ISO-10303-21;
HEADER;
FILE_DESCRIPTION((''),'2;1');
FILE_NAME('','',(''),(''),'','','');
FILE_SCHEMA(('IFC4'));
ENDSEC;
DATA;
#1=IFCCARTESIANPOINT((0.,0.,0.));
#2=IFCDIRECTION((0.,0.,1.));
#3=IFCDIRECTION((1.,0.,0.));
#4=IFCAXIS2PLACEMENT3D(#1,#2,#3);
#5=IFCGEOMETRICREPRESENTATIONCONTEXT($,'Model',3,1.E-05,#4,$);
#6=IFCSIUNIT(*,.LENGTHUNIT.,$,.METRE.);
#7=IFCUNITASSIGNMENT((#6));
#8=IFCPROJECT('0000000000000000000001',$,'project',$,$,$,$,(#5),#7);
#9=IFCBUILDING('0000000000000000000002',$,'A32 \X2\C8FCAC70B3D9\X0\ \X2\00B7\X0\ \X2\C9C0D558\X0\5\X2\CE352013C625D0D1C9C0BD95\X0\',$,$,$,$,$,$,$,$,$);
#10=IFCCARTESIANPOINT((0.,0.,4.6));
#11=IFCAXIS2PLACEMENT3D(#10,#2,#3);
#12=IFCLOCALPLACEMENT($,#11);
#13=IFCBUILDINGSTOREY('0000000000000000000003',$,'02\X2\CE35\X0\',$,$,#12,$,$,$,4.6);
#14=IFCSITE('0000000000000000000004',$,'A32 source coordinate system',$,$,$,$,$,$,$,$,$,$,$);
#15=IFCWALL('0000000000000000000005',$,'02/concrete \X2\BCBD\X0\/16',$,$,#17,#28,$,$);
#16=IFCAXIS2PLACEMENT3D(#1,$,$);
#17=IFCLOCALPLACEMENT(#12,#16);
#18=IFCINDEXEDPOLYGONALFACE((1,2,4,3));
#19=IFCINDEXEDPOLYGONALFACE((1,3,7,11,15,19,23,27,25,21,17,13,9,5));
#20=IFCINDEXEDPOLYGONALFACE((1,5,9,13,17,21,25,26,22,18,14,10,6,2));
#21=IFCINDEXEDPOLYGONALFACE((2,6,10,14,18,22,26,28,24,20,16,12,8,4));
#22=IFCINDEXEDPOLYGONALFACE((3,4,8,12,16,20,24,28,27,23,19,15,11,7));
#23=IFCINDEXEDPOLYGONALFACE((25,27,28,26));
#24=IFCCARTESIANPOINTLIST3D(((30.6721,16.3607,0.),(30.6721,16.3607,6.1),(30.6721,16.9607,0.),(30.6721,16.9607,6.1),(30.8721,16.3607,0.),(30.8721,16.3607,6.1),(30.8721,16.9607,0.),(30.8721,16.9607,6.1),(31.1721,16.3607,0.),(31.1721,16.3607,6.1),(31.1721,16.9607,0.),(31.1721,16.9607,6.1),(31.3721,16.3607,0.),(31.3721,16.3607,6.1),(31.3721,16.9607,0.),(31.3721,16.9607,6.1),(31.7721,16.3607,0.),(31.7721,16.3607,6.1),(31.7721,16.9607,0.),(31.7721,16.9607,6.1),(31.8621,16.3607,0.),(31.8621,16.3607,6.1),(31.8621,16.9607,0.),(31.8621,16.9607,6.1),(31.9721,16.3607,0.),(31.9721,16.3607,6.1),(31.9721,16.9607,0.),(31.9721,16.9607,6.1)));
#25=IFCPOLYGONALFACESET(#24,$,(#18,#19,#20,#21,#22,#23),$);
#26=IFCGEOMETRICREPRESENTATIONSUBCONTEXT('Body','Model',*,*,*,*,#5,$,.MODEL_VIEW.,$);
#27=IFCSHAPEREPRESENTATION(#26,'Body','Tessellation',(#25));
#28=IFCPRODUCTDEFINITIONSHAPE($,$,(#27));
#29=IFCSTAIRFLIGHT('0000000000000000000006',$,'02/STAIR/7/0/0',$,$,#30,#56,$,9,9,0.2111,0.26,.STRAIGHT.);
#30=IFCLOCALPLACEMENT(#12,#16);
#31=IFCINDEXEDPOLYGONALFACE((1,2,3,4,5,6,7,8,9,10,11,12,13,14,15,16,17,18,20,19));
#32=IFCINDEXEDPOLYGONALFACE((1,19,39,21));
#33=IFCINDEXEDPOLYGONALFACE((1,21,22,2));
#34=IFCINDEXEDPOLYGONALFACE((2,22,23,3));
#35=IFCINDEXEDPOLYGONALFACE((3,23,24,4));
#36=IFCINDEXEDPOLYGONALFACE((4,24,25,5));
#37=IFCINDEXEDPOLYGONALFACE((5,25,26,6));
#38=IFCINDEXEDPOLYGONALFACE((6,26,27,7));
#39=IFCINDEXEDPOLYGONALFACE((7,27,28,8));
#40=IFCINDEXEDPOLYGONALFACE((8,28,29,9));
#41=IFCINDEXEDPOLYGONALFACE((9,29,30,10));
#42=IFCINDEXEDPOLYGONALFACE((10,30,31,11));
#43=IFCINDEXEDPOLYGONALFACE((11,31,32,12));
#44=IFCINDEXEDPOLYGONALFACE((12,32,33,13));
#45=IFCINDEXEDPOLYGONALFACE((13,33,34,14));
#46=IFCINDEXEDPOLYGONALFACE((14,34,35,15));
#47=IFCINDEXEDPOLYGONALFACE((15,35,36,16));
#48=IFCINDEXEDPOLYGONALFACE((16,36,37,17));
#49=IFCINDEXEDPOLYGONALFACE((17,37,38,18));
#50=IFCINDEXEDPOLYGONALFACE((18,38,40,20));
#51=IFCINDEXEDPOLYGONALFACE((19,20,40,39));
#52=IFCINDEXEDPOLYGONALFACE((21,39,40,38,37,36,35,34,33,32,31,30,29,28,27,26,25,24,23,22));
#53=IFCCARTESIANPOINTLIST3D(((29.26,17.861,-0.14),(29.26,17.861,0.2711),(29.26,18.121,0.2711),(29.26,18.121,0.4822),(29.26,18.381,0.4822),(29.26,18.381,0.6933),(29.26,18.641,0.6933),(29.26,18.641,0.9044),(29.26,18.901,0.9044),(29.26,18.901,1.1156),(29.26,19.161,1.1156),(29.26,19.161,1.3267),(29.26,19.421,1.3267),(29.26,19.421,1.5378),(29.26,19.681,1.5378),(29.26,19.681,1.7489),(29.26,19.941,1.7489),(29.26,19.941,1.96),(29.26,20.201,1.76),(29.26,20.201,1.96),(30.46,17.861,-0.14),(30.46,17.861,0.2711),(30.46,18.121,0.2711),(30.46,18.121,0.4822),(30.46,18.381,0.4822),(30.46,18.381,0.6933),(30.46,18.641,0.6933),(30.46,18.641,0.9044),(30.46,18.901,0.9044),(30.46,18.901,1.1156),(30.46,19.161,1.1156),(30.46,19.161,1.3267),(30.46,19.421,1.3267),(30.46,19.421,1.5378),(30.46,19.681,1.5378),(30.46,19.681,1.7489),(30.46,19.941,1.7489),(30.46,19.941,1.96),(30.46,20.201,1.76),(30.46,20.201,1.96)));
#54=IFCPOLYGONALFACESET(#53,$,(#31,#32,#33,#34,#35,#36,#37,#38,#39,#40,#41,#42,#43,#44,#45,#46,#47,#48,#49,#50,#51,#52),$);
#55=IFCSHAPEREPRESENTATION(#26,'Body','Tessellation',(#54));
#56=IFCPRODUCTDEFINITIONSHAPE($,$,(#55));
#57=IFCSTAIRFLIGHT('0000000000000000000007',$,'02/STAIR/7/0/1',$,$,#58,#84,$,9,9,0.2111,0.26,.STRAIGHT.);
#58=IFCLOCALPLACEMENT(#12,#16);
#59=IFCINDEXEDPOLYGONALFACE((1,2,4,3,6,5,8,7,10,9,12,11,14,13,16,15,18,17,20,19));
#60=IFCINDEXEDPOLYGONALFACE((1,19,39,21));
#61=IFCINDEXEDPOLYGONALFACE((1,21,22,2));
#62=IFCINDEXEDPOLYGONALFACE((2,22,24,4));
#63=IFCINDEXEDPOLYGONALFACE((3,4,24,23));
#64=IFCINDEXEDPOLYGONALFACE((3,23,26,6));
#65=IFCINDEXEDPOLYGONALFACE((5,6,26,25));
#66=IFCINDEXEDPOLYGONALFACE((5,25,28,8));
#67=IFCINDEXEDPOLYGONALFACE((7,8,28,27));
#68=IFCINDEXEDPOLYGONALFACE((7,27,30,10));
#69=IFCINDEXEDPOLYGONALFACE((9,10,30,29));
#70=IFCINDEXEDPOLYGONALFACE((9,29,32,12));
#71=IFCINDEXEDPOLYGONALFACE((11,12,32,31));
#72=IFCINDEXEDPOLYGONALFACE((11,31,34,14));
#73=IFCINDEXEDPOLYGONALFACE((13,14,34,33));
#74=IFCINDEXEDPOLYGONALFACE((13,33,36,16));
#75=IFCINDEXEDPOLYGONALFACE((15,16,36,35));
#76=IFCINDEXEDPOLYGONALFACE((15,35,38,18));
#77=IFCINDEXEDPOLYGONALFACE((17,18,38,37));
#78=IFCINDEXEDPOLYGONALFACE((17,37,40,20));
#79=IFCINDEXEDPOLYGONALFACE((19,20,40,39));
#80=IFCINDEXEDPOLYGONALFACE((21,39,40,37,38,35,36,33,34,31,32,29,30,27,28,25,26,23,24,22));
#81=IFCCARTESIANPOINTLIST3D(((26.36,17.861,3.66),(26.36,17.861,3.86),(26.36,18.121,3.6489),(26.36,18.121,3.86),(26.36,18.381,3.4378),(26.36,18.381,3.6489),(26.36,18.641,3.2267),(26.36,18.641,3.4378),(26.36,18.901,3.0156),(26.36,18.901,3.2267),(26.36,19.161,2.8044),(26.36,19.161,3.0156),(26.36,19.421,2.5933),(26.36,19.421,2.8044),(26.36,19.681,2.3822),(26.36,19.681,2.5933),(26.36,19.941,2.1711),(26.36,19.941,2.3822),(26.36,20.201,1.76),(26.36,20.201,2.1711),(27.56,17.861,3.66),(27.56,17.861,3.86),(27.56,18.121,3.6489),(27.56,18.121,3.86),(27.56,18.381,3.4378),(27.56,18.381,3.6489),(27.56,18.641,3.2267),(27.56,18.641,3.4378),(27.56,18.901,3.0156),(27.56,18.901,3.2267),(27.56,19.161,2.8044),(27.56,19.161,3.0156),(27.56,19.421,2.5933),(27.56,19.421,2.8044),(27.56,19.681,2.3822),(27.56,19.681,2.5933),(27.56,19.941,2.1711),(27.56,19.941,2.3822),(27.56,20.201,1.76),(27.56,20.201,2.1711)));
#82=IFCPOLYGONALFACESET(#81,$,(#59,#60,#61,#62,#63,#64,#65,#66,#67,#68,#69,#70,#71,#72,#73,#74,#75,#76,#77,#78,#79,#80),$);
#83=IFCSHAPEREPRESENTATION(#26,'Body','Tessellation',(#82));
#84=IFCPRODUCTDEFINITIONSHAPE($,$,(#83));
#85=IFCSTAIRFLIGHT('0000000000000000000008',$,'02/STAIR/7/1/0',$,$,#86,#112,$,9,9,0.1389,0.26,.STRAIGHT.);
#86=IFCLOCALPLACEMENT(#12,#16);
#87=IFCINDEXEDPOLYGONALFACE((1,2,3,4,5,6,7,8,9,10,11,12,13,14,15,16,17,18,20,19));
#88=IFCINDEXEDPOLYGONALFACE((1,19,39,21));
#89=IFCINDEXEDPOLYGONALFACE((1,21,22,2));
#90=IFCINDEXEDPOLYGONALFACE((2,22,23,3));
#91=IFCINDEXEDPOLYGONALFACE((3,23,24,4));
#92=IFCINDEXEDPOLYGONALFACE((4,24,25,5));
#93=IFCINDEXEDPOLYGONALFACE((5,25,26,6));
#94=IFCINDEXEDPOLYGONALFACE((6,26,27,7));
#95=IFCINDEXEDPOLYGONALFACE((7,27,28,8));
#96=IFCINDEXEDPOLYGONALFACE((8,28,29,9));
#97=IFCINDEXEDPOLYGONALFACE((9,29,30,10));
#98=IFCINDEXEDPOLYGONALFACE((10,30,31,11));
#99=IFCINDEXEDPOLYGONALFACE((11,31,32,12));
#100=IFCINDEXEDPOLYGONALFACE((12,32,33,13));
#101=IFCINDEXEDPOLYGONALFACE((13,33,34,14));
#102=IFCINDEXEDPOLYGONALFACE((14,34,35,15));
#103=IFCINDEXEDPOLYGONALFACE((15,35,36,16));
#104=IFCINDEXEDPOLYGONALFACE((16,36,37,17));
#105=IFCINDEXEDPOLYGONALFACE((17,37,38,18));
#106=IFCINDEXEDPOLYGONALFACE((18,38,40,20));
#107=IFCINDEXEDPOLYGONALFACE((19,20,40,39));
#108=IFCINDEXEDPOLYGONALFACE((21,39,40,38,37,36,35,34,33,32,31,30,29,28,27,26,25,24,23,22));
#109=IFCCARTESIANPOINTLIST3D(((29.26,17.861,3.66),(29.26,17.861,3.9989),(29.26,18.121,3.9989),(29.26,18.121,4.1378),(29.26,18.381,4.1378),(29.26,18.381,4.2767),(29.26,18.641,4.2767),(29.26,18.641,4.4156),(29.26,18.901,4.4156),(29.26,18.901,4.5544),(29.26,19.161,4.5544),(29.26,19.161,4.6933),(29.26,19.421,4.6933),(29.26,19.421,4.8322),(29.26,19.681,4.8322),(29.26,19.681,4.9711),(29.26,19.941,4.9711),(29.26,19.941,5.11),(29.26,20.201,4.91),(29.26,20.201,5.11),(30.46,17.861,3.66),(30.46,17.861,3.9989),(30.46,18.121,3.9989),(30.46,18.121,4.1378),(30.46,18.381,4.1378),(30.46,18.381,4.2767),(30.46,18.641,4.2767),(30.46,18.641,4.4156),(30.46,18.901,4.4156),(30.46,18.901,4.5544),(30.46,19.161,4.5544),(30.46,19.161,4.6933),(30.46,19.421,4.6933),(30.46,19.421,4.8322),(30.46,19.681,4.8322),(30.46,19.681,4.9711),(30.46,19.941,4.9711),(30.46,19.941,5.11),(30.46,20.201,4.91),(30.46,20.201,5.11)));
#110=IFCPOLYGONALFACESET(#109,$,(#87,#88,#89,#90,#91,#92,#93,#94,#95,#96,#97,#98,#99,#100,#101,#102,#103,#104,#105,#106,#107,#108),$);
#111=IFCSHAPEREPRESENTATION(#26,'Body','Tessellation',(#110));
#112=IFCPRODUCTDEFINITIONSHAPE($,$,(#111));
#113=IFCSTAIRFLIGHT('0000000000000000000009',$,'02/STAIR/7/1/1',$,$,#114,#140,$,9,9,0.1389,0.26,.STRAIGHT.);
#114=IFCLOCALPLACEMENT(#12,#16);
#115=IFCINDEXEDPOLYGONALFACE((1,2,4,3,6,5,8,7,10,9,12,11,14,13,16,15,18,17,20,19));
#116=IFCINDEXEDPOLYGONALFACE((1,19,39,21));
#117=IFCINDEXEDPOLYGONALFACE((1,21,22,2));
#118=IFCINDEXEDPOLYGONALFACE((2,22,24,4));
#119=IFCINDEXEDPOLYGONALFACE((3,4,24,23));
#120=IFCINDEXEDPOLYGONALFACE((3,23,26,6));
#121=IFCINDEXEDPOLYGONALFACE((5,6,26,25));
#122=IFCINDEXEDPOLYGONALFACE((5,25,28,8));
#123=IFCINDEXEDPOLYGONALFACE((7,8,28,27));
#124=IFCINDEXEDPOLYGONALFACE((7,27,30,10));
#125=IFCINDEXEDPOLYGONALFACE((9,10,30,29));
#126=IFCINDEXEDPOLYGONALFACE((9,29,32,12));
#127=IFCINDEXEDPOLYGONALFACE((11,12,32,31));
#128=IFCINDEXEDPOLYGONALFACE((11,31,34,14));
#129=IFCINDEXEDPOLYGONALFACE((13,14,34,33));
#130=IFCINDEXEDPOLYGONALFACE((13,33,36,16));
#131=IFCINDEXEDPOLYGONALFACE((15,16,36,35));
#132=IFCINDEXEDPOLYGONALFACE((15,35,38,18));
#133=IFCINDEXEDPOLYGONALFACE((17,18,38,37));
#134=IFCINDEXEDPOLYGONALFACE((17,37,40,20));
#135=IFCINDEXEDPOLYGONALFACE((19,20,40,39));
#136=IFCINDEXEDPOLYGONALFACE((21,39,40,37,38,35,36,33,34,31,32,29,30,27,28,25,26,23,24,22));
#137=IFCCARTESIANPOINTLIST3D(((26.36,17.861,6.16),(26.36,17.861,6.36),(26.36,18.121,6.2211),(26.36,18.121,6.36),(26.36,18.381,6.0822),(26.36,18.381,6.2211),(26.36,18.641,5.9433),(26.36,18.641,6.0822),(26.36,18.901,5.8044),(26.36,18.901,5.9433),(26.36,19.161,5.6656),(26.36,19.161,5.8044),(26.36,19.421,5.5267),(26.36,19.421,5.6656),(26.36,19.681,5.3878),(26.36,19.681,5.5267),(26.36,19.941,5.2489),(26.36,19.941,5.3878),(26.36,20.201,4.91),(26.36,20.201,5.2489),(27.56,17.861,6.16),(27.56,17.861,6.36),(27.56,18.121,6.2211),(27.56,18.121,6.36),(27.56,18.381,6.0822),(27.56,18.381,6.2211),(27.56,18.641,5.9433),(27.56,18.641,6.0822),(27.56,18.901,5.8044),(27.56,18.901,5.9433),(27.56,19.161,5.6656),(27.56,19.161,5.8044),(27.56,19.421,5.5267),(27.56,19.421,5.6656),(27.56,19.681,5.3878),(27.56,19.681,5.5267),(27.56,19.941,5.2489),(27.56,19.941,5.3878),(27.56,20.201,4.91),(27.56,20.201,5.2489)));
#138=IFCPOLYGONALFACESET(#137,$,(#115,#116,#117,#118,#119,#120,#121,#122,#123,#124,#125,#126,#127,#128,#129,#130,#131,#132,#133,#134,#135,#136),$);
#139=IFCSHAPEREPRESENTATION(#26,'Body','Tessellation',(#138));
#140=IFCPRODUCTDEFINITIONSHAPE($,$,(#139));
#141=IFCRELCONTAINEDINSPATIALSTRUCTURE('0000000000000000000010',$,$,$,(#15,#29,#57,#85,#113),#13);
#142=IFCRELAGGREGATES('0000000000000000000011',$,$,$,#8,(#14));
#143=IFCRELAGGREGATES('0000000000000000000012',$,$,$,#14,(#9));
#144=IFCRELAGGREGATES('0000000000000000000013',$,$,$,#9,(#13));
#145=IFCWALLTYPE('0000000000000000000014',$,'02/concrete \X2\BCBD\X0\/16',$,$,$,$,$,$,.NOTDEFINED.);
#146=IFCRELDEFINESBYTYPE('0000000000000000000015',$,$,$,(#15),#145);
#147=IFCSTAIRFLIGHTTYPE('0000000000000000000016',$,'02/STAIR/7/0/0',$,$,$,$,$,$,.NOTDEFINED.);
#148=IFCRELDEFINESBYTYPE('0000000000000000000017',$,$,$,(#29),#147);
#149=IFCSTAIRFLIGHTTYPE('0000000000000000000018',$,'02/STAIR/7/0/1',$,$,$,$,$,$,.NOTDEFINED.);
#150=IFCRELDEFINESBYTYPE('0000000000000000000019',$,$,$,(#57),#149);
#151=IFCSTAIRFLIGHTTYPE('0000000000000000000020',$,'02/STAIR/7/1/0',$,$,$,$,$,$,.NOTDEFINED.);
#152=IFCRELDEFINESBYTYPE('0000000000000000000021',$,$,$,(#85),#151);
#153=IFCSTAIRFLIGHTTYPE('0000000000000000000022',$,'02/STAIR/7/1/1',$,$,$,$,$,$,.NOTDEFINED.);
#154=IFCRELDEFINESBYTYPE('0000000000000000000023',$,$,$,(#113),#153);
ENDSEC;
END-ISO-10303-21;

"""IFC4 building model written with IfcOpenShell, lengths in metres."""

from ifc_helpers import new_model, si_unit, frame, origin, origin_with_axes, place, context, subcontext, project, spatial, polyline, outline, extrude, source, transform, mapped, type_object, type_shapes, element, save


model = new_model("IFC4")

# Units and contexts
model_context = context("Model", 3, precision=1e-05, world=origin_with_axes())
body_context = subcontext(model_context, "Body", "Model", "MODEL_VIEW")
ifc_project = project(units=[si_unit("LENGTHUNIT", "METRE")], contexts=[model_context])

# Site, building, storey
site = spatial("IfcSite", under=ifc_project, Name="A32 source coordinate system")
building = spatial("IfcBuilding", under=site, Name="A32 주거동 · 지하5층–옥탑지붕")
storey_placement = place(None, frame((0.0, 0.0, 4.6), z_axis=(0.0, 0.0, 1.0), x_axis=(1.0, 0.0, 0.0)))
storey = spatial("IfcBuildingStorey", under=building, at=storey_placement, Name="02층", Elevation=4.6)

# Wall
wall_type_1 = type_object("IfcWallType", Name="02/concrete 벽/16", PredefinedType="NOTDEFINED")
shared_shape_1 = source(origin(), body_context, "Body", "SweptSolid", [
    extrude(outline(polyline([(31.3721, 16.9607), (31.7721, 16.9607), (31.8621, 16.9607), (31.9721, 16.9607), (31.9721, 16.3607), (31.8621, 16.3607), (31.7721, 16.3607), (31.3721, 16.3607), (31.1721, 16.3607), (30.8721, 16.3607), (30.6721, 16.3607), (30.6721, 16.9607), (30.8721, 16.9607), (31.1721, 16.9607), (31.3721, 16.9607)])), origin(), (0.0, 0.0, 1.0), 6.1),
])
type_shapes(wall_type_1, [shared_shape_1])
wall_1_placement = place(storey_placement, origin_with_axes())
element("IfcWall", 1, at=wall_1_placement, inside=storey, type_object=wall_type_1, Name="02/concrete 벽/16", context=body_context, shape_type="MappedRepresentation", body=[
    mapped(shared_shape_1, transform((0.0, 0.0, 0.0), scale=1.0)),
])

# Stair flights
stair_flight_type_1 = type_object("IfcStairFlightType", Name="02/STAIR/7/0/0", PredefinedType="NOTDEFINED")
shared_shape_2 = source(origin(), body_context, "Body", "SweptSolid", [
    extrude(outline(polyline([(0.0, -0.14), (2.34, 1.76), (2.34, 1.96), (2.08, 1.96), (2.08, 1.7489), (1.82, 1.7489), (1.82, 1.5378), (1.56, 1.5378), (1.56, 1.3267), (1.3, 1.3267), (1.3, 1.1156), (1.04, 1.1156), (1.04, 0.9044), (0.78, 0.9044), (0.78, 0.6933), (0.52, 0.6933), (0.52, 0.4822), (0.26, 0.4822), (0.26, 0.2711), (0.0, 0.2711), (0.0, -0.14)])), frame((29.26, 17.861, 0.0), z_axis=(1.0, 0.0, 0.0), x_axis=(0.0, 1.0, 0.0)), (0.0, 0.0, 1.0), 1.2),
])
type_shapes(stair_flight_type_1, [shared_shape_2])
stair_flight_1_placement = place(storey_placement, origin_with_axes())
element("IfcStairFlight", 2, at=stair_flight_1_placement, inside=storey, type_object=stair_flight_type_1, Name="02/STAIR/7/0/0", NumberOfRisers=9, NumberOfTreads=9, PredefinedType="STRAIGHT", RiserHeight=0.2111, TreadLength=0.26, context=body_context, shape_type="MappedRepresentation", body=[
    mapped(shared_shape_2, transform((0.0, 0.0, 0.0), scale=1.0)),
])
stair_flight_type_2 = type_object("IfcStairFlightType", Name="02/STAIR/7/0/1", PredefinedType="NOTDEFINED")
shared_shape_3 = source(origin(), body_context, "Body", "SweptSolid", [
    extrude(outline(polyline([(0.0, 1.76), (2.34, 3.66), (2.34, 3.86), (2.08, 3.86), (2.08, 3.6489), (1.82, 3.6489), (1.82, 3.4378), (1.56, 3.4378), (1.56, 3.2267), (1.3, 3.2267), (1.3, 3.0156), (1.04, 3.0156), (1.04, 2.8044), (0.78, 2.8044), (0.78, 2.5933), (0.52, 2.5933), (0.52, 2.3822), (0.26, 2.3822), (0.26, 2.1711), (0.0, 2.1711), (0.0, 1.76)])), frame((27.56, 20.201, 0.0), z_axis=(-1.0, 0.0, 0.0), x_axis=(0.0, -1.0, 0.0)), (0.0, 0.0, 1.0), 1.2),
])
type_shapes(stair_flight_type_2, [shared_shape_3])
stair_flight_2_placement = place(storey_placement, origin_with_axes())
element("IfcStairFlight", 3, at=stair_flight_2_placement, inside=storey, type_object=stair_flight_type_2, Name="02/STAIR/7/0/1", NumberOfRisers=9, NumberOfTreads=9, PredefinedType="STRAIGHT", RiserHeight=0.2111, TreadLength=0.26, context=body_context, shape_type="MappedRepresentation", body=[
    mapped(shared_shape_3, transform((0.0, 0.0, 0.0), scale=1.0)),
])
stair_flight_type_3 = type_object("IfcStairFlightType", Name="02/STAIR/7/1/0", PredefinedType="NOTDEFINED")
shared_shape_4 = source(origin(), body_context, "Body", "SweptSolid", [
    extrude(outline(polyline([(0.0, 3.66), (2.34, 4.91), (2.34, 5.11), (2.08, 5.11), (2.08, 4.9711), (1.82, 4.9711), (1.82, 4.8322), (1.56, 4.8322), (1.56, 4.6933), (1.3, 4.6933), (1.3, 4.5544), (1.04, 4.5544), (1.04, 4.4156), (0.78, 4.4156), (0.78, 4.2767), (0.52, 4.2767), (0.52, 4.1378), (0.26, 4.1378), (0.26, 3.9989), (0.0, 3.9989), (0.0, 3.66)])), frame((29.26, 17.861, 0.0), z_axis=(1.0, 0.0, 0.0), x_axis=(0.0, 1.0, 0.0)), (0.0, 0.0, 1.0), 1.2),
])
type_shapes(stair_flight_type_3, [shared_shape_4])
stair_flight_3_placement = place(storey_placement, origin_with_axes())
element("IfcStairFlight", 4, at=stair_flight_3_placement, inside=storey, type_object=stair_flight_type_3, Name="02/STAIR/7/1/0", NumberOfRisers=9, NumberOfTreads=9, PredefinedType="STRAIGHT", RiserHeight=0.1389, TreadLength=0.26, context=body_context, shape_type="MappedRepresentation", body=[
    mapped(shared_shape_4, transform((0.0, 0.0, 0.0), scale=1.0)),
])
stair_flight_type_4 = type_object("IfcStairFlightType", Name="02/STAIR/7/1/1", PredefinedType="NOTDEFINED")
shared_shape_5 = source(origin(), body_context, "Body", "SweptSolid", [
    extrude(outline(polyline([(0.0, 4.91), (2.34, 6.16), (2.34, 6.36), (2.08, 6.36), (2.08, 6.2211), (1.82, 6.2211), (1.82, 6.0822), (1.56, 6.0822), (1.56, 5.9433), (1.3, 5.9433), (1.3, 5.8044), (1.04, 5.8044), (1.04, 5.6656), (0.78, 5.6656), (0.78, 5.5267), (0.52, 5.5267), (0.52, 5.3878), (0.26, 5.3878), (0.26, 5.2489), (0.0, 5.2489), (0.0, 4.91)])), frame((27.56, 20.201, 0.0), z_axis=(-1.0, 0.0, 0.0), x_axis=(0.0, -1.0, 0.0)), (0.0, 0.0, 1.0), 1.2),
])
type_shapes(stair_flight_type_4, [shared_shape_5])
stair_flight_4_placement = place(storey_placement, origin_with_axes())
element("IfcStairFlight", 5, at=stair_flight_4_placement, inside=storey, type_object=stair_flight_type_4, Name="02/STAIR/7/1/1", NumberOfRisers=9, NumberOfTreads=9, PredefinedType="STRAIGHT", RiserHeight=0.1389, TreadLength=0.26, context=body_context, shape_type="MappedRepresentation", body=[
    mapped(shared_shape_5, transform((0.0, 0.0, 0.0), scale=1.0)),
])

save(model, "model.ifc")
